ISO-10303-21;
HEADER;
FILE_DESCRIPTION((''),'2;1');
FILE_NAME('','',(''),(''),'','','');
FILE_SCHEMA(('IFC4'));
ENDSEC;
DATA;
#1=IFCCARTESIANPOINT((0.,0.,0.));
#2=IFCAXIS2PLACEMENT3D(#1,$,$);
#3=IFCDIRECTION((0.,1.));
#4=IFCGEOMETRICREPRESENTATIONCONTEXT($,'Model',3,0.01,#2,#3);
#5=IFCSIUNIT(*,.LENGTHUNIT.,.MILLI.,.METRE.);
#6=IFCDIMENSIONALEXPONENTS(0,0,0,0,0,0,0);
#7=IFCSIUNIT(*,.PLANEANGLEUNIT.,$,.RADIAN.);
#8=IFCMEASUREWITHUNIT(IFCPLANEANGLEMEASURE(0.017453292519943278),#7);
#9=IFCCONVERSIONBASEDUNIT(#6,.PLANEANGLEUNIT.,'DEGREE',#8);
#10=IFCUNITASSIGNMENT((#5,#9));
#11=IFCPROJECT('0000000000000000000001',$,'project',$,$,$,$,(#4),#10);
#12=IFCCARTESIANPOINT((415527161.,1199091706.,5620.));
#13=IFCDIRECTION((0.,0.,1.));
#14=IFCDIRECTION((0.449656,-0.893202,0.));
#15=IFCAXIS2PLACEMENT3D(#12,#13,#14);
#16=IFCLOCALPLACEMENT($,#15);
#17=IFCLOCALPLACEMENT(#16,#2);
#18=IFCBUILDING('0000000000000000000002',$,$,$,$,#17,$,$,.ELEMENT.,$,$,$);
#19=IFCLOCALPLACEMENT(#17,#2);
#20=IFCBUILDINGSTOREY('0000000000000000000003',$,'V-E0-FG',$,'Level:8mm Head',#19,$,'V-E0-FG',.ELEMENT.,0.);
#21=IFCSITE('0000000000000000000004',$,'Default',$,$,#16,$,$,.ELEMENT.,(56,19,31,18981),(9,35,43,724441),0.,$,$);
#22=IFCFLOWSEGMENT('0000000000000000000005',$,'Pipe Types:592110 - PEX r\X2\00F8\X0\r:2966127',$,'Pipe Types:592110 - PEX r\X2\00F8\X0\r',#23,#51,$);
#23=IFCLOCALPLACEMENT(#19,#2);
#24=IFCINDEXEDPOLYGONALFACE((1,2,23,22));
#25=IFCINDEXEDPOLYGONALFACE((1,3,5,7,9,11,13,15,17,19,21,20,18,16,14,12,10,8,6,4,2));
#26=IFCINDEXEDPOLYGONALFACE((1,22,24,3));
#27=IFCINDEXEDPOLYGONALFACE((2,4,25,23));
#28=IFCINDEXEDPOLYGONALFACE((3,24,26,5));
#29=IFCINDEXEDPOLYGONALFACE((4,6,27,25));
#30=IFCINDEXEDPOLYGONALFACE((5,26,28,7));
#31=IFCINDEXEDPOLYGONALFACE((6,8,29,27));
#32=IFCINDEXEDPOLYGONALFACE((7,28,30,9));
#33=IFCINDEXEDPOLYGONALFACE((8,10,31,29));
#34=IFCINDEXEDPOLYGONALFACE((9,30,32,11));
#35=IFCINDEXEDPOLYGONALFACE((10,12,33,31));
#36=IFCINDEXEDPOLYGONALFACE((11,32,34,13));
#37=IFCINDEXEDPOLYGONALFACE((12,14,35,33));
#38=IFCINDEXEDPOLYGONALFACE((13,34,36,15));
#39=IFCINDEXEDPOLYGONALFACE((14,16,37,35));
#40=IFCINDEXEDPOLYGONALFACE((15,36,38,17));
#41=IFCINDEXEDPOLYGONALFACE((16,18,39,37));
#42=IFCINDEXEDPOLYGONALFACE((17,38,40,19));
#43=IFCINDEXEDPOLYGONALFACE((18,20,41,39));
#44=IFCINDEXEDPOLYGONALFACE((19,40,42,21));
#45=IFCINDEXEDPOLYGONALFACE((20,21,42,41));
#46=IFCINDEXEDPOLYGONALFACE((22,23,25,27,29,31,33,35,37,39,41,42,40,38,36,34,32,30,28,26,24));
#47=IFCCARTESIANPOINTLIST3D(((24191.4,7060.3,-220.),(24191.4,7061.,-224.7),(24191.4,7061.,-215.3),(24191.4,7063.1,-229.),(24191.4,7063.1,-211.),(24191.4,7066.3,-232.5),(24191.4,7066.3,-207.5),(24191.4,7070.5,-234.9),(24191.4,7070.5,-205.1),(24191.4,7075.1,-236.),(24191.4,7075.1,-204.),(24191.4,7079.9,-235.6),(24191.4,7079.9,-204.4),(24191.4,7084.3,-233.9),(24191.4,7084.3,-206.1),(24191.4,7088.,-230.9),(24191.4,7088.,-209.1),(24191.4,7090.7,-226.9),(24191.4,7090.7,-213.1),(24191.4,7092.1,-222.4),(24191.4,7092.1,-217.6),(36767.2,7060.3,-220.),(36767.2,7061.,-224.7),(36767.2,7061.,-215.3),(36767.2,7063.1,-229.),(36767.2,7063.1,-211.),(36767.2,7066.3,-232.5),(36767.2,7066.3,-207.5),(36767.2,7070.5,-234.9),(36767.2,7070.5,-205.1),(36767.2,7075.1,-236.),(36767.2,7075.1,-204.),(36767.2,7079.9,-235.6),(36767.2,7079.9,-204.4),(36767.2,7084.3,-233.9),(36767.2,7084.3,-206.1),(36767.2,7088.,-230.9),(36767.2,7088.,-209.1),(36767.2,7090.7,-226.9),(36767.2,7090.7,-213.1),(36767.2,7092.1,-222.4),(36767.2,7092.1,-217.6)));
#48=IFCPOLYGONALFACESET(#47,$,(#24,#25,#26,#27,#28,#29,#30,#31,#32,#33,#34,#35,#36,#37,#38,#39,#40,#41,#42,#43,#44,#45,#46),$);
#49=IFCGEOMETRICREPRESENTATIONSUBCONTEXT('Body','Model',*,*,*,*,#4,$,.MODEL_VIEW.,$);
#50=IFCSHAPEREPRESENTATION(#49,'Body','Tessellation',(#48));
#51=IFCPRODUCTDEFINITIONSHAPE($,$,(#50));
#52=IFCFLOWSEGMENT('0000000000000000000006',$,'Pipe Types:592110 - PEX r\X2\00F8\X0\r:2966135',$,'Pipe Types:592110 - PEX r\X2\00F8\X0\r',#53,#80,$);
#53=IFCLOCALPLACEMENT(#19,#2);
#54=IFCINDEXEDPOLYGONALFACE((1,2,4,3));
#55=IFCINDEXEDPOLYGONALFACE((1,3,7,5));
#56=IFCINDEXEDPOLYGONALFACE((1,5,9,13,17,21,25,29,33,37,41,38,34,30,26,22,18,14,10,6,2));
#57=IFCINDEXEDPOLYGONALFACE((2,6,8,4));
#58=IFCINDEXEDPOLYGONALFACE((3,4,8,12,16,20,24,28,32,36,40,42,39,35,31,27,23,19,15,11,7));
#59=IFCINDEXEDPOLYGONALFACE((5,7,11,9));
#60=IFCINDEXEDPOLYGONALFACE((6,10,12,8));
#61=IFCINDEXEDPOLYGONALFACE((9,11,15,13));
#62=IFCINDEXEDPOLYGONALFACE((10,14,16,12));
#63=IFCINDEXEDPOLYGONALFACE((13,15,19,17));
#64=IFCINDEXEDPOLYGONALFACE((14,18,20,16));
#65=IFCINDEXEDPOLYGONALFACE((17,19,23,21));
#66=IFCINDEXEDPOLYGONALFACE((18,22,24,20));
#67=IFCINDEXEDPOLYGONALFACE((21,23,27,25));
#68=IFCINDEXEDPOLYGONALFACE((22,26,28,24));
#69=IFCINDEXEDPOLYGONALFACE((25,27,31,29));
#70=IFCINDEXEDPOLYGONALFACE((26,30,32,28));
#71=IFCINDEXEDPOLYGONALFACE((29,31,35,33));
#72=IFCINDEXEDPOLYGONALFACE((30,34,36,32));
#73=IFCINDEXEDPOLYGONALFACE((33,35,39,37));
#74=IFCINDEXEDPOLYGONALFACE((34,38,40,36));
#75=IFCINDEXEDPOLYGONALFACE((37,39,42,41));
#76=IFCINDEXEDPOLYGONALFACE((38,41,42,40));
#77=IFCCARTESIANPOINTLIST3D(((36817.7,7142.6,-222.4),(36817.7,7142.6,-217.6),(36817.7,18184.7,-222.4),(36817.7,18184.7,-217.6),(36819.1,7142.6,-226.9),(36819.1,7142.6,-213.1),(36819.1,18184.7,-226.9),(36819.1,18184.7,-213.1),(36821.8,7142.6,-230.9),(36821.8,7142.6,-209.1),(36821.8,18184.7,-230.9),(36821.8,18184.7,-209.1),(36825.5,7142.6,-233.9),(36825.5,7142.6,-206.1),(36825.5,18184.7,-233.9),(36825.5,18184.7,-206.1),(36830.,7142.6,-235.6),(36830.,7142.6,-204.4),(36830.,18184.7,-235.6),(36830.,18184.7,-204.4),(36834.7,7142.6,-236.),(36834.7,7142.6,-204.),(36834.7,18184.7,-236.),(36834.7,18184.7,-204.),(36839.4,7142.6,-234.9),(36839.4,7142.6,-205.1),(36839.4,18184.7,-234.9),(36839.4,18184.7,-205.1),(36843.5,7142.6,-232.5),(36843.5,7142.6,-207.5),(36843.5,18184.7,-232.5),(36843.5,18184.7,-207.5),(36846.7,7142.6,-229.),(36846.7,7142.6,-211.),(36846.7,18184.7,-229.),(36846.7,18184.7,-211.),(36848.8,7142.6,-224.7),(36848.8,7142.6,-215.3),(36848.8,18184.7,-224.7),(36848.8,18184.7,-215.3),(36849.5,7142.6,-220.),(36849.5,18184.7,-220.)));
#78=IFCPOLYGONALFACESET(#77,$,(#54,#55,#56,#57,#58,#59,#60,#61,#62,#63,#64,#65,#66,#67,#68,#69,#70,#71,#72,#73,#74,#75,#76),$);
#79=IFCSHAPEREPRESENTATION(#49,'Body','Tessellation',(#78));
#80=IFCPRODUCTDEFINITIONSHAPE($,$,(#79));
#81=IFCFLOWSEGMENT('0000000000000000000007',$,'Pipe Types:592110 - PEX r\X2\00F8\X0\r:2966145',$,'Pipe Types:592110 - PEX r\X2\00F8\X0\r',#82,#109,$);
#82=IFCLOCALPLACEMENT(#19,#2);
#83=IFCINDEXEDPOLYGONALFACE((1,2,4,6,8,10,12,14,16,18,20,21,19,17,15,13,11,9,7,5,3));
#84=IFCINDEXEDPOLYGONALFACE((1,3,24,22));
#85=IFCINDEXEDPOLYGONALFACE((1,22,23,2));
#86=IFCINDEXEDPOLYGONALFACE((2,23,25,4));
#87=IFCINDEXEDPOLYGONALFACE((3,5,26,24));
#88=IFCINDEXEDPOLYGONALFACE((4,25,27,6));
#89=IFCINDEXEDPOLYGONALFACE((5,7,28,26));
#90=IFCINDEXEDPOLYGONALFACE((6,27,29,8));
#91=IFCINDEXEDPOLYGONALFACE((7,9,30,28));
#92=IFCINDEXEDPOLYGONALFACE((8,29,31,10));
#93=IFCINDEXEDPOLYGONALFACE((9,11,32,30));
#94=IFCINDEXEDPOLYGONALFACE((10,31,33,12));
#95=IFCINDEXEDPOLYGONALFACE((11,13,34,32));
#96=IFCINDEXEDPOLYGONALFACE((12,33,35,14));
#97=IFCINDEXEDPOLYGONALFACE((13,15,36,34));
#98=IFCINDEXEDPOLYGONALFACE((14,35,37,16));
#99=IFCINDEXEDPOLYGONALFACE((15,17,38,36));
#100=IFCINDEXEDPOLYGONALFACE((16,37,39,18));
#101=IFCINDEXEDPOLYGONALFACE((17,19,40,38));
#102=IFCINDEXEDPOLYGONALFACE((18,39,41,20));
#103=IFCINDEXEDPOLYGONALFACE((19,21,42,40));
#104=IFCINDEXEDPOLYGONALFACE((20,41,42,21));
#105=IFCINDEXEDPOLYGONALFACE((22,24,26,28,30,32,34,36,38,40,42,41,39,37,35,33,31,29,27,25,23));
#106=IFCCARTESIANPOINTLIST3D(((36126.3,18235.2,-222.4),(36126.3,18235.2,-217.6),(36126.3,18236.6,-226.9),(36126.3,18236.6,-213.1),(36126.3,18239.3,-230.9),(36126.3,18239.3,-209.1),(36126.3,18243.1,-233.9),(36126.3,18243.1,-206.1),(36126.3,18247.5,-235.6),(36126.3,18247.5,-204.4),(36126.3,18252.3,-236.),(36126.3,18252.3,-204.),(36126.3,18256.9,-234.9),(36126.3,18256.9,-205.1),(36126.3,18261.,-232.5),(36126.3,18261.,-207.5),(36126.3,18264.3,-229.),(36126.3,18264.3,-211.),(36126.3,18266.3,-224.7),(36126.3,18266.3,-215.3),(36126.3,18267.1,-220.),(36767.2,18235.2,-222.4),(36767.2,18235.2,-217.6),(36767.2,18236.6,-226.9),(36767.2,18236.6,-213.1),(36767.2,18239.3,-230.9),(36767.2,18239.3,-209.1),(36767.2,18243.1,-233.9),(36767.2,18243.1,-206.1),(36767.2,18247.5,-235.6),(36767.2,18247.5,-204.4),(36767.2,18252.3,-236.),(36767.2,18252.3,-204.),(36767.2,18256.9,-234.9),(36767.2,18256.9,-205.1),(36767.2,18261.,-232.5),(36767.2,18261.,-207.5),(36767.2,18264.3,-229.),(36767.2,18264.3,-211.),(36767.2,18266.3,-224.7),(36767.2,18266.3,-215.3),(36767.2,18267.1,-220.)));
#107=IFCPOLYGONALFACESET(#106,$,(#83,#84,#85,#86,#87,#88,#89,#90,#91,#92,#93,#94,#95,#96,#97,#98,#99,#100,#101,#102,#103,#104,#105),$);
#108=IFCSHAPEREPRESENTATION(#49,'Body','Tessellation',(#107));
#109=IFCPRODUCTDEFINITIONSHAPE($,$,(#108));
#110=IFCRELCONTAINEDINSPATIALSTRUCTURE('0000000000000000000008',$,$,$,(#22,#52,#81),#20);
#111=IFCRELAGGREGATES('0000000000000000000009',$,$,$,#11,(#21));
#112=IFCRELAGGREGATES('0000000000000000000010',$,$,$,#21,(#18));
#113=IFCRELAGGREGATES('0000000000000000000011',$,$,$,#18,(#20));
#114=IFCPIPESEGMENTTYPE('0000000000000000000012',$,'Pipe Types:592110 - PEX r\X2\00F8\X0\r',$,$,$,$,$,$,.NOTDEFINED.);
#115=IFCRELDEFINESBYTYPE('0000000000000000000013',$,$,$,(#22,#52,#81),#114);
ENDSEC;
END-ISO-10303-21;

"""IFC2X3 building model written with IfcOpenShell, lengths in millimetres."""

from ifc_helpers import new_model, entity, si_unit, converted_unit, direction, frame, frame_2d, origin, origin_2d_with_axis, place, context, subcontext, project, spatial, circle, extrude, type_object, element, save


model = new_model("IFC2X3")

# Units and contexts
model_context = context("Model", 3, precision=0.01, world=origin(), true_north=direction((0.0, 1.0)))
body_context = subcontext(model_context, "Body", "Model", "MODEL_VIEW")
ifc_project = project(units=[si_unit("LENGTHUNIT", "METRE", prefix="MILLI"), converted_unit("PLANEANGLEUNIT", "DEGREE", entity("IfcPlaneAngleMeasure", 0.017453292519943278), si_unit("PLANEANGLEUNIT", "RADIAN"), dimensions=[0, 0, 0, 0, 0, 0, 0])], contexts=[model_context])

# Site, building, storey
site_placement = place(None, frame((415527161.0, 1199091706.0, 5620.0), z_axis=(0.0, 0.0, 1.0), x_axis=(0.449656, -0.893202, 0.0)))
site = spatial("IfcSite", under=ifc_project, at=site_placement, Name="Default", CompositionType="ELEMENT", RefLatitude=(56, 19, 31, 18981), RefLongitude=(9, 35, 43, 724441), RefElevation=0.0)
building_placement = place(site_placement, origin())
building = spatial("IfcBuilding", under=site, at=building_placement, CompositionType="ELEMENT")
storey_placement = place(building_placement, origin())
storey = spatial("IfcBuildingStorey", under=building, at=storey_placement, Name="V-E0-FG", ObjectType="Level:8mm Head", LongName="V-E0-FG", CompositionType="ELEMENT", Elevation=0.0)

# Flow segments
pipe_segment_type_1 = type_object("IfcPipeSegmentType", Name="Pipe Types:592110 - PEX rør", PredefinedType="NOTDEFINED")
flow_segment_1_placement = place(storey_placement, origin())
element("IfcFlowSegment", 1, at=flow_segment_1_placement, inside=storey, type_object=pipe_segment_type_1, Name="Pipe Types:592110 - PEX rør:2966127", ObjectType="Pipe Types:592110 - PEX rør", context=body_context, shape_type="SweptSolid", body=[
    extrude(circle(Radius=16.0, at=origin_2d_with_axis()), frame((24191.4, 7076.3, -220.0), z_axis=(1.0, 0.0, 0.0), x_axis=(0.0, -1.0, 0.0)), (0.0, 0.0, 1.0), 12575.8),
])
flow_segment_2_placement = place(storey_placement, origin())
element("IfcFlowSegment", 2, at=flow_segment_2_placement, inside=storey, type_object=pipe_segment_type_1, Name="Pipe Types:592110 - PEX rør:2966135", ObjectType="Pipe Types:592110 - PEX rør", context=body_context, shape_type="SweptSolid", body=[
    extrude(circle(Radius=16.0, at=frame_2d((0.0, 0.0), x_axis=(1.0, 0.0))), frame((36833.5, 7142.6, -220.0), z_axis=(0.0, 1.0, 0.0), x_axis=(1.0, 0.0, 0.0)), (0.0, 0.0, 1.0), 11042.1),
])
flow_segment_3_placement = place(storey_placement, origin())
element("IfcFlowSegment", 3, at=flow_segment_3_placement, inside=storey, type_object=pipe_segment_type_1, Name="Pipe Types:592110 - PEX rør:2966145", ObjectType="Pipe Types:592110 - PEX rør", context=body_context, shape_type="SweptSolid", body=[
    extrude(circle(Radius=16.0, at=frame_2d((0.0, 0.0), x_axis=(1.0, 0.0))), frame((36126.3, 18251.1, -220.0), z_axis=(1.0, 0.0, 0.0), x_axis=(0.0, 1.0, 0.0)), (0.0, 0.0, 1.0), 640.9),
])

save(model, "model.ifc")
